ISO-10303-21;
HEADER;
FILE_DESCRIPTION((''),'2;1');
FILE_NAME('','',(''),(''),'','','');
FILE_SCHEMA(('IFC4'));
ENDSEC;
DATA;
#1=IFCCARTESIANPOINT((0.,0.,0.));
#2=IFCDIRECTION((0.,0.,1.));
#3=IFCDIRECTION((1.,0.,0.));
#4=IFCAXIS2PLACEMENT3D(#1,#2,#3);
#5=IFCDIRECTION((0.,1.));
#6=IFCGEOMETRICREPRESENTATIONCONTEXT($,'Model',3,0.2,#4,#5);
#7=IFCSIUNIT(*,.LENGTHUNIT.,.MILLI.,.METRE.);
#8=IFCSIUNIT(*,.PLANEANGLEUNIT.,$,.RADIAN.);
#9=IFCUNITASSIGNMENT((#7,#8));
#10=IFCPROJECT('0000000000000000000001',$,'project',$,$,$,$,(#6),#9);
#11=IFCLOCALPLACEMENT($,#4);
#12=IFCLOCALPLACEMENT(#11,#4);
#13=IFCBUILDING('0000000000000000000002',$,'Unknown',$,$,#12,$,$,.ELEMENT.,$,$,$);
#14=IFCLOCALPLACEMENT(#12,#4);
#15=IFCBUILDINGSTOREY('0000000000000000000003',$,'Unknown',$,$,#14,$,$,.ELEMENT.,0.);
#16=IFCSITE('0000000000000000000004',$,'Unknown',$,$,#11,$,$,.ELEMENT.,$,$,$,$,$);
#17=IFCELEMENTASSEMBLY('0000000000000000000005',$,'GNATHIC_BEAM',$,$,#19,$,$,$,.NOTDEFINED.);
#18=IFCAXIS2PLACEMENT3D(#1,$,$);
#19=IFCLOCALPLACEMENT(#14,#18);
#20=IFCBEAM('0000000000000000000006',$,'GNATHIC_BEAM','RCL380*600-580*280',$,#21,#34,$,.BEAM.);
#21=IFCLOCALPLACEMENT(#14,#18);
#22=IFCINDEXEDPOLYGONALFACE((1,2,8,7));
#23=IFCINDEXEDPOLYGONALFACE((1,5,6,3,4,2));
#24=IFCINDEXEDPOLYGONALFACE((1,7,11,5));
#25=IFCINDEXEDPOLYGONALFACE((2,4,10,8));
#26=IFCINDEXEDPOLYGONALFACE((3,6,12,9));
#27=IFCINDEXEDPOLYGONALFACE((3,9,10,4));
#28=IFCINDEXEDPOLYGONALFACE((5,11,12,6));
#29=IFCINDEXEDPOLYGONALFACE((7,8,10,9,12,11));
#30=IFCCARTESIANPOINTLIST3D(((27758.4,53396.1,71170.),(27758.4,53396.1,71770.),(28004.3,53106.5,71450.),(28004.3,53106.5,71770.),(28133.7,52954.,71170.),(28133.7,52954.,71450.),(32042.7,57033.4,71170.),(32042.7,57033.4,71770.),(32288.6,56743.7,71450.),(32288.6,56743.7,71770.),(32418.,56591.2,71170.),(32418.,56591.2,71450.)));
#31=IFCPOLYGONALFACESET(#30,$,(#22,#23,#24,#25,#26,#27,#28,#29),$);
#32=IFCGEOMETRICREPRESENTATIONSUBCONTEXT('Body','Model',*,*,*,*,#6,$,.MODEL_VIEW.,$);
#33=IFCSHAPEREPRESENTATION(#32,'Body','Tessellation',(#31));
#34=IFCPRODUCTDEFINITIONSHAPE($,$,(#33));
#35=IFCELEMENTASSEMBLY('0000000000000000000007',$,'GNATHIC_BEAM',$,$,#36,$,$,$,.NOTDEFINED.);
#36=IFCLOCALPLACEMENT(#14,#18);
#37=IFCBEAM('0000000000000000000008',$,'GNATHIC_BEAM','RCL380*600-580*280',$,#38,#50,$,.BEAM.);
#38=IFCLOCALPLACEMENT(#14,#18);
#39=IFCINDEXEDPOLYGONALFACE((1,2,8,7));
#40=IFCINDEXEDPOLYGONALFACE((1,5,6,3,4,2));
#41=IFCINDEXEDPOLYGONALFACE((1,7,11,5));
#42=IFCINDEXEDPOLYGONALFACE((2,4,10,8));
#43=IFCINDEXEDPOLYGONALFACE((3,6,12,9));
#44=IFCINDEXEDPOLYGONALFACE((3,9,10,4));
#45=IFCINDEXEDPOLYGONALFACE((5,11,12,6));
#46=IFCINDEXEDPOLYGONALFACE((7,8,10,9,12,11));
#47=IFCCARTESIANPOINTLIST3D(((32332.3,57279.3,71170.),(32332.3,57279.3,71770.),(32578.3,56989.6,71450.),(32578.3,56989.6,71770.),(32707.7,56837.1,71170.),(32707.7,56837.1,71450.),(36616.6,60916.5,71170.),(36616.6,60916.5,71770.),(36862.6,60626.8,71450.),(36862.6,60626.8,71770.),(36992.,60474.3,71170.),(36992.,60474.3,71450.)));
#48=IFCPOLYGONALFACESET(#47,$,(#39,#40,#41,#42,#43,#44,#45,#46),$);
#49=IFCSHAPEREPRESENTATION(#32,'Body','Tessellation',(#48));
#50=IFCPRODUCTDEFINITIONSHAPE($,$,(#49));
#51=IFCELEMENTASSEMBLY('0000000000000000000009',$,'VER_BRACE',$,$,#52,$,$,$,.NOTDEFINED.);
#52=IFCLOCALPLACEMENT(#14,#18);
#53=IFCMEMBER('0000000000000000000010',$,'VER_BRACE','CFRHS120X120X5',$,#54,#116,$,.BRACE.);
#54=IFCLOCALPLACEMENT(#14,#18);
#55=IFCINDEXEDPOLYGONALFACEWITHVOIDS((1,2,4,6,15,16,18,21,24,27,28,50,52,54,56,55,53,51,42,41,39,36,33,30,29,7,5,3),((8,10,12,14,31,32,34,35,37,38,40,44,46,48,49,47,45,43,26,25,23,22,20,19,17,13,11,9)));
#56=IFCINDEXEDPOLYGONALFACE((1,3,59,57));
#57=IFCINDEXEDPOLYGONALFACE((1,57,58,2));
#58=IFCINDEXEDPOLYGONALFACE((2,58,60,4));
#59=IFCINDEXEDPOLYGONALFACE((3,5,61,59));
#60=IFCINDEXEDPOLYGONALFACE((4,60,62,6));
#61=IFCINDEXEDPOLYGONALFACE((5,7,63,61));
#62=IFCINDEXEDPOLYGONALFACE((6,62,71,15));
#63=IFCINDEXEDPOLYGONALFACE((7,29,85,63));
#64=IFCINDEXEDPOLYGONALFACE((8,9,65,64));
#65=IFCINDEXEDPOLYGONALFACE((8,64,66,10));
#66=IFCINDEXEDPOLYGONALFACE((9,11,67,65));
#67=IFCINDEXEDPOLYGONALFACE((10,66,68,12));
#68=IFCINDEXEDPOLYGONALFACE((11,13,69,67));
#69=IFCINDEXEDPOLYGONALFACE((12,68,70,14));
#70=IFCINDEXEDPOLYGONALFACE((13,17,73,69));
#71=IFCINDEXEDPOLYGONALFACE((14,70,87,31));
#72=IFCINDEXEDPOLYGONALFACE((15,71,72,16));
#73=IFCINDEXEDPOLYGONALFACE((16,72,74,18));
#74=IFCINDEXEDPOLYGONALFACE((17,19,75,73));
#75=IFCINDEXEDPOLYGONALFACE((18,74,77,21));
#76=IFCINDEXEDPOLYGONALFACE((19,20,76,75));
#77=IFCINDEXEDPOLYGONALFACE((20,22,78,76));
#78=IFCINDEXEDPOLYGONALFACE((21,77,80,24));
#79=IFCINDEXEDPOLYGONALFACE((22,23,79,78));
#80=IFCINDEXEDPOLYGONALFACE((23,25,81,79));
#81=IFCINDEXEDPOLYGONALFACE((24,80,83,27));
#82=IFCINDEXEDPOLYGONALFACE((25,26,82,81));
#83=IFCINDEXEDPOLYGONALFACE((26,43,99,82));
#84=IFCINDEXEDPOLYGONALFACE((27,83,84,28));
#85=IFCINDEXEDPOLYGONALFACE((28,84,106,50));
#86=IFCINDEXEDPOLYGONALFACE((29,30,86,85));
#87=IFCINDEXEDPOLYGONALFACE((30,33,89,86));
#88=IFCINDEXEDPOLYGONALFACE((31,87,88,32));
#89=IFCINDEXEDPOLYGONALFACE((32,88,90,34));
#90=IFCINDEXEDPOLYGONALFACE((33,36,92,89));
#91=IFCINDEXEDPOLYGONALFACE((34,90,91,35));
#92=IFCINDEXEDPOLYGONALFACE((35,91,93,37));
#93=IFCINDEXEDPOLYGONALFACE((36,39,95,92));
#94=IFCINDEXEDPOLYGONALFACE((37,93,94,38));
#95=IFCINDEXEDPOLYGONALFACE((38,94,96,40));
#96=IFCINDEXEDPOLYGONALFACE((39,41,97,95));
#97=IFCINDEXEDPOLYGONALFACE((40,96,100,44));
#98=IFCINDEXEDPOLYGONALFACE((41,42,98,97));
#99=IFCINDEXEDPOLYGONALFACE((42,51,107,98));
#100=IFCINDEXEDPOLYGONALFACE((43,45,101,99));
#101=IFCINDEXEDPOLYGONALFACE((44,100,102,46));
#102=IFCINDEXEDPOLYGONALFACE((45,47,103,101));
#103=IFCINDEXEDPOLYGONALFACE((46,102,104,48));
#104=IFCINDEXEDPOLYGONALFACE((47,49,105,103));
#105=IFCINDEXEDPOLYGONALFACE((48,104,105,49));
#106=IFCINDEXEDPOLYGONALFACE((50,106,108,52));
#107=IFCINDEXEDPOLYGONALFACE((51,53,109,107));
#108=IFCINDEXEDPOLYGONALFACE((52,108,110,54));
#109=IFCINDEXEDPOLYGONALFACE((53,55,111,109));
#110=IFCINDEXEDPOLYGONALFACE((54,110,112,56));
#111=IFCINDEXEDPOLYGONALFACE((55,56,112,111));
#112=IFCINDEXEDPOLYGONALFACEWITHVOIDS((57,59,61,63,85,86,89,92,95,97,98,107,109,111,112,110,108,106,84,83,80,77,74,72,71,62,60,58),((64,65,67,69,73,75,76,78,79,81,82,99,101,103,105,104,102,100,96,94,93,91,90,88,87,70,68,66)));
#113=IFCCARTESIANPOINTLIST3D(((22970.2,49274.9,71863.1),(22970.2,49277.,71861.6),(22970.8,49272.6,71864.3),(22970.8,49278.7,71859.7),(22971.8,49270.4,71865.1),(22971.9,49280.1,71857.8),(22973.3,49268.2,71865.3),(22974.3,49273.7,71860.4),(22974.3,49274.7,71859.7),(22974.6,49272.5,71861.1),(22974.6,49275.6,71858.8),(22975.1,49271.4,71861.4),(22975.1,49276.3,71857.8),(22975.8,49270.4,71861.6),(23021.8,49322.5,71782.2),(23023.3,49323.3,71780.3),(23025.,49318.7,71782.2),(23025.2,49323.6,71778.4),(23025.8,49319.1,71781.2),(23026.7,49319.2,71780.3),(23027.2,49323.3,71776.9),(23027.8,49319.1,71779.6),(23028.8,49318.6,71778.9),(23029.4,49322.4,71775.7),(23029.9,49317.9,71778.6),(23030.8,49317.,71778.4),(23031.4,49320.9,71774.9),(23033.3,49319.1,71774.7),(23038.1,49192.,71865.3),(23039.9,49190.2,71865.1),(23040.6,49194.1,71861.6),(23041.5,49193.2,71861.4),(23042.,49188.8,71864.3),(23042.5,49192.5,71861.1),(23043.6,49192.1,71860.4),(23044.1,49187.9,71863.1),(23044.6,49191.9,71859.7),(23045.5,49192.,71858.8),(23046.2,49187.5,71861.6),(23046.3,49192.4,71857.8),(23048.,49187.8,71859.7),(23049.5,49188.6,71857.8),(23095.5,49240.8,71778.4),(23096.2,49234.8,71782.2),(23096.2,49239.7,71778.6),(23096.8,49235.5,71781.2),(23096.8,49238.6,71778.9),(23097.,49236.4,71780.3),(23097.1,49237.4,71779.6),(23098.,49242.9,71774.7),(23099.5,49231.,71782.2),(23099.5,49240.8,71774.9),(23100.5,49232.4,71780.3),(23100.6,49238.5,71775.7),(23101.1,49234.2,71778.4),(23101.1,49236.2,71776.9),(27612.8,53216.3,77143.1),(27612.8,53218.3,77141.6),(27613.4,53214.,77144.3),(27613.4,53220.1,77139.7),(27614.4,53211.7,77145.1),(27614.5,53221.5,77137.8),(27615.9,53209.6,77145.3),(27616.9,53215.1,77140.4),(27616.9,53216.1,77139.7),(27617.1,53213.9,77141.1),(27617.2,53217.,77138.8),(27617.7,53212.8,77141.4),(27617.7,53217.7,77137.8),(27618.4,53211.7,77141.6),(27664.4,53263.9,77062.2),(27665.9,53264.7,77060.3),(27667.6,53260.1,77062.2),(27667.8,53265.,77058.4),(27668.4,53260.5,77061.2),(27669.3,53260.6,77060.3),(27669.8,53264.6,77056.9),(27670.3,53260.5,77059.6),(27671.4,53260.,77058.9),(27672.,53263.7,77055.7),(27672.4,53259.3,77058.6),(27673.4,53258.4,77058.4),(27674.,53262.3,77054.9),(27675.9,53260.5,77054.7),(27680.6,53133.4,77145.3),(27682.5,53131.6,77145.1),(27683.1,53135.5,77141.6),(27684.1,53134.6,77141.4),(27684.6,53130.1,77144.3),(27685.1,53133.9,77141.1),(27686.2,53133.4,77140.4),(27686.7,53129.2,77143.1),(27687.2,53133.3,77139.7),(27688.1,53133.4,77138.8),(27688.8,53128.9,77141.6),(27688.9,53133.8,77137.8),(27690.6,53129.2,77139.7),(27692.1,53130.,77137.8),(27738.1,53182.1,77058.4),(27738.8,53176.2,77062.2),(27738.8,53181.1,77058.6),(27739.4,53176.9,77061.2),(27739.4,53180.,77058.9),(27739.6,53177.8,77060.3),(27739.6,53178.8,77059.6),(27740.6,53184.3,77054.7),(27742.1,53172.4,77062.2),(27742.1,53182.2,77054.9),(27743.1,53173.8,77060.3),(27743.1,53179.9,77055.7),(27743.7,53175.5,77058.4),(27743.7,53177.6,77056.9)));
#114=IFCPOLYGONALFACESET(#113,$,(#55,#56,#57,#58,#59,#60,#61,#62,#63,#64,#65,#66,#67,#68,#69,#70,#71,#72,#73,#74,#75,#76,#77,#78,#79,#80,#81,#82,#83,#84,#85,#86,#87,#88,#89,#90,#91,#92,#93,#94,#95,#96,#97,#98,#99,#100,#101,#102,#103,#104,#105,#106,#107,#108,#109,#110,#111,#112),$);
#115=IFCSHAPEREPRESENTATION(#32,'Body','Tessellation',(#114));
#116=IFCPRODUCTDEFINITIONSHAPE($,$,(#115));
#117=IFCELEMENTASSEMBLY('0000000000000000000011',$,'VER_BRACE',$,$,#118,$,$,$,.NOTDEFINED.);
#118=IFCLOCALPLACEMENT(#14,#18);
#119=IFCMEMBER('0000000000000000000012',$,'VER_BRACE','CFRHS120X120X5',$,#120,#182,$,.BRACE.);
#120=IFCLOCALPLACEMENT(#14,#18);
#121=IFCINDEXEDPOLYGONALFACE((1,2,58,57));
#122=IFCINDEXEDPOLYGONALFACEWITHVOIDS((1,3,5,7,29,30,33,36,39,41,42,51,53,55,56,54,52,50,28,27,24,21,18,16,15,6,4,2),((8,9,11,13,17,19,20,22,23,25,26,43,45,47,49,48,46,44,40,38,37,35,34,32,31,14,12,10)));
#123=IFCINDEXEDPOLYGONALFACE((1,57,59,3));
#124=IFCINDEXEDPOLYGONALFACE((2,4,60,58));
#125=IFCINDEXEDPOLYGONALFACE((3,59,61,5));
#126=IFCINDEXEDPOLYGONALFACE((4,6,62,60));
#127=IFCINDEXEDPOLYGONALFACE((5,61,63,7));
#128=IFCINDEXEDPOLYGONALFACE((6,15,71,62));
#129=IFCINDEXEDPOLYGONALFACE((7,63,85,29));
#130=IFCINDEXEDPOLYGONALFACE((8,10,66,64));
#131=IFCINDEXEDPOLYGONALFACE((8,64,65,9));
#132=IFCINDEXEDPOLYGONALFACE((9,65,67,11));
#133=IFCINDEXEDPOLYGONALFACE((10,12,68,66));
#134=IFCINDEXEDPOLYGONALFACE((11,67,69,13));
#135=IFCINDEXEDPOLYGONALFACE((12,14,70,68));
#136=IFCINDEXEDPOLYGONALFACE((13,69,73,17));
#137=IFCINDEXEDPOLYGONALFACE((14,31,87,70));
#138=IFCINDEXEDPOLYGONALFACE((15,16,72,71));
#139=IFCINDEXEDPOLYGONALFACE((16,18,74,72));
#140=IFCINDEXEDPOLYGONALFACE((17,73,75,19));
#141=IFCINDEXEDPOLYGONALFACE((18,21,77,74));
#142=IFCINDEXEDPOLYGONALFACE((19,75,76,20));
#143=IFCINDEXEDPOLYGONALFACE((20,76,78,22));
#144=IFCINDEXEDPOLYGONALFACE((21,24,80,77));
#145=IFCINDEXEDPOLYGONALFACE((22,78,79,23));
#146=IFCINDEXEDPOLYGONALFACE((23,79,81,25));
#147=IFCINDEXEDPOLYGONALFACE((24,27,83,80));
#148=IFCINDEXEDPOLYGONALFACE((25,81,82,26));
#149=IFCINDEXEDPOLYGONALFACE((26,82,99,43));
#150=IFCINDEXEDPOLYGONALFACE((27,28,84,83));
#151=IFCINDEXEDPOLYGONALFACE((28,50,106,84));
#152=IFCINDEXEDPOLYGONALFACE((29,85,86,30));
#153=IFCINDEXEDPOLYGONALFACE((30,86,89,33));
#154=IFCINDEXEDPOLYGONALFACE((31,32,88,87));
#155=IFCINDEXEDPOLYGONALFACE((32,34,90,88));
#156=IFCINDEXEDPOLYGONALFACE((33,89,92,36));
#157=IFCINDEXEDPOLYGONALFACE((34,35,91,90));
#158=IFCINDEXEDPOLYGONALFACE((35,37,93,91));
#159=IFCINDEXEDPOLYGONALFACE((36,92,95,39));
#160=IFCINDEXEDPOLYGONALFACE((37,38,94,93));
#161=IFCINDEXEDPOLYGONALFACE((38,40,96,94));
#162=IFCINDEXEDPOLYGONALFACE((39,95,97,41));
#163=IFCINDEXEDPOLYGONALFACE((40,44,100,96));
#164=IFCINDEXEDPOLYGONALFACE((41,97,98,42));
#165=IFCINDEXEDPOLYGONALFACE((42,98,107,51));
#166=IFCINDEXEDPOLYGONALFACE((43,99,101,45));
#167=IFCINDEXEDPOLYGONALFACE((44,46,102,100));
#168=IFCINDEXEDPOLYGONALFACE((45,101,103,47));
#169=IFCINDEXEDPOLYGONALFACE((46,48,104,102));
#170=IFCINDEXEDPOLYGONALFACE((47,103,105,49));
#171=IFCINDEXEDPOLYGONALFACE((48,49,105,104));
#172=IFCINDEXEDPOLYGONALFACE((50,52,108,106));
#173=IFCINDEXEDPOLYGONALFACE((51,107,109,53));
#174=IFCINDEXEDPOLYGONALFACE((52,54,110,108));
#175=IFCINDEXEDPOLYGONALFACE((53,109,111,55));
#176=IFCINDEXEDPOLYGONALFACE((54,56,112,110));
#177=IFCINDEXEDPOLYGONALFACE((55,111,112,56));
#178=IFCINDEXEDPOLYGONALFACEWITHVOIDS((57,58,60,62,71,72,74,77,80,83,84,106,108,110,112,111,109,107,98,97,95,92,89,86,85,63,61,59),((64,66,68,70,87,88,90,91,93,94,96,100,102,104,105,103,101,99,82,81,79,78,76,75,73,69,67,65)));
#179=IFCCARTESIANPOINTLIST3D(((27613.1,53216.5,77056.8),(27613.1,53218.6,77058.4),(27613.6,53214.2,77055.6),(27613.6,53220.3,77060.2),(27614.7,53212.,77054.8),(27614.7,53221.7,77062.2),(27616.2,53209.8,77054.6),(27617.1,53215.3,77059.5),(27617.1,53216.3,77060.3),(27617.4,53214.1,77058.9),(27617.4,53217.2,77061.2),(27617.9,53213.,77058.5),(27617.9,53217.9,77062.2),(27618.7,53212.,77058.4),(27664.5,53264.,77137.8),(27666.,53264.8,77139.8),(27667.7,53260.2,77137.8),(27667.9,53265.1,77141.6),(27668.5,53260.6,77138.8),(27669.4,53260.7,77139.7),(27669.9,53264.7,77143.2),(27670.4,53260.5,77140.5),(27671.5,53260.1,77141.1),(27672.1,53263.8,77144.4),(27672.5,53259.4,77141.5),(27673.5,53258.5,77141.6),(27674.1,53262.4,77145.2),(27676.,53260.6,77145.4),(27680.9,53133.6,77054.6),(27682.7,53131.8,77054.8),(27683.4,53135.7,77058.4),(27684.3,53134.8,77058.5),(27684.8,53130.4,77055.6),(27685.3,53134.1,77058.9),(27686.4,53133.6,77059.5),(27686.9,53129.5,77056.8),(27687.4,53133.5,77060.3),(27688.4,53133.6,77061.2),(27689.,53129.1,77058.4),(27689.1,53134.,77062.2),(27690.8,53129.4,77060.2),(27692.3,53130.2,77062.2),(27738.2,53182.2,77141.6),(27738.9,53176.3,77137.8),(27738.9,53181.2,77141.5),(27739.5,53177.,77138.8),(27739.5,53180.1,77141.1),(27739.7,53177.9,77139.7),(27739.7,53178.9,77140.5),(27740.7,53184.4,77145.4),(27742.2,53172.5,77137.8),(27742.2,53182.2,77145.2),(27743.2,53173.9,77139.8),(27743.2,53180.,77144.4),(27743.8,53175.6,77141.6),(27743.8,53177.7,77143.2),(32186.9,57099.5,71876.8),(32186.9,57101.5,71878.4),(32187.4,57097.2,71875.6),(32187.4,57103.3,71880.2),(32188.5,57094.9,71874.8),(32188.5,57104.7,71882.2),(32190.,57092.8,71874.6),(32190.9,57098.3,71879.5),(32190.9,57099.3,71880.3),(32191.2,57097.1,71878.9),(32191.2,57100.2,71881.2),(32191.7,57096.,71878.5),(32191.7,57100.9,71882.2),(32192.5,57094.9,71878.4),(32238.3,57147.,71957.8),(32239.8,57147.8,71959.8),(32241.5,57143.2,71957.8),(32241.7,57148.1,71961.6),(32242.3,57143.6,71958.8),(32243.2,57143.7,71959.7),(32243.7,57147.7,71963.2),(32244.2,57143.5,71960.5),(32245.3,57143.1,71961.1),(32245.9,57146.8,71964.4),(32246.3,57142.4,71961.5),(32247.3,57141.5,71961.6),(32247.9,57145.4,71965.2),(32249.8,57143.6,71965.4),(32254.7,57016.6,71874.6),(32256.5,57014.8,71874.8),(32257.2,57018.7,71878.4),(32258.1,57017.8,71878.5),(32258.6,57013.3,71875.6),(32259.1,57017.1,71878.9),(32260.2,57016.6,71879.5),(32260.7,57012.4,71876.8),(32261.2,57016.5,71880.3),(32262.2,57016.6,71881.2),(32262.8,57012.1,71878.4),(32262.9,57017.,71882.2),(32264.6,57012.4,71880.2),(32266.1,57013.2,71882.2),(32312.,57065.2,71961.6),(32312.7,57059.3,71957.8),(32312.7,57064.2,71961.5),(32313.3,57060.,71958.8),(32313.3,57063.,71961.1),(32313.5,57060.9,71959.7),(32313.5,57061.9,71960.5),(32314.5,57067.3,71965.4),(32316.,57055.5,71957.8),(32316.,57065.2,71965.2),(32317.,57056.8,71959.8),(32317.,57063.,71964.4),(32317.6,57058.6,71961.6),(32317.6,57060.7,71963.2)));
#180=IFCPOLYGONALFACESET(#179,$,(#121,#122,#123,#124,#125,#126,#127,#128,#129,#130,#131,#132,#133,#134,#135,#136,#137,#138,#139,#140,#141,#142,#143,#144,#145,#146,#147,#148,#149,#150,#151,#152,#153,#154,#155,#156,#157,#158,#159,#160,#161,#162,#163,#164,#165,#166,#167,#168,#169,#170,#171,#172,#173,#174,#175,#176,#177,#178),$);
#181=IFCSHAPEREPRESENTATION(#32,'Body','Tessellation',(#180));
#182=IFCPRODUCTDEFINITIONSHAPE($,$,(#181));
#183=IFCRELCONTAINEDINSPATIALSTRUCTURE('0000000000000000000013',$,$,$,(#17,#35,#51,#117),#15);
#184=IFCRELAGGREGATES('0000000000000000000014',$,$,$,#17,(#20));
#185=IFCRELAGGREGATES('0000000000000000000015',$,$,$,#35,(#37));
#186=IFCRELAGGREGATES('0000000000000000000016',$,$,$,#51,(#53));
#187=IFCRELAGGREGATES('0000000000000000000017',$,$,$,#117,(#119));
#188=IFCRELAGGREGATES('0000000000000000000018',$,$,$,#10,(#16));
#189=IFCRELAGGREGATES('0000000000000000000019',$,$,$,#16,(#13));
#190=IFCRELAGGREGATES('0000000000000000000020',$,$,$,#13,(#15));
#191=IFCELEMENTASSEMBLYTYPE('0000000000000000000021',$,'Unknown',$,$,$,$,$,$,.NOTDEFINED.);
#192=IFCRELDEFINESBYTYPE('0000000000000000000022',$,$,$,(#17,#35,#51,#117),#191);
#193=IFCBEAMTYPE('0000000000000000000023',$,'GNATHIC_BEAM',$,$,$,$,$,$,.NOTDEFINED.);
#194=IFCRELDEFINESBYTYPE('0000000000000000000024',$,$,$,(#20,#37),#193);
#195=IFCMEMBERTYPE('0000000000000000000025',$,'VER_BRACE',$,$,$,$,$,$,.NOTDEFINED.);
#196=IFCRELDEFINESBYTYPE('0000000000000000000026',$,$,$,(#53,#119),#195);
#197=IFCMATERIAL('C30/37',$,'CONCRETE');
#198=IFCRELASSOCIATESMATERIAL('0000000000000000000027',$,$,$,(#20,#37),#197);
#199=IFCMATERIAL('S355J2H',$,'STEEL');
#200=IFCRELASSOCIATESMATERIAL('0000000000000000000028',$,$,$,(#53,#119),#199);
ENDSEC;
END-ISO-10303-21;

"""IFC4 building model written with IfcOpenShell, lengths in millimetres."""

from ifc_helpers import new_model, si_unit, direction, frame, origin_with_axes, origin_2d_with_axis, place, context, subcontext, project, spatial, polyline, hollow_rectangle, outline, extrude, material, material_profile, profile_set, profile_usage, type_object, element, aggregate, save


model = new_model("IFC4")

# Units and contexts
model_context = context("Model", 3, precision=0.2, world=origin_with_axes(), true_north=direction((0.0, 1.0)))
body_context = subcontext(model_context, "Body", "Model", "MODEL_VIEW")
ifc_project = project(units=[si_unit("LENGTHUNIT", "METRE", prefix="MILLI"), si_unit("PLANEANGLEUNIT", "RADIAN")], contexts=[model_context])

# Site, building, storey
site_placement = place(None, origin_with_axes())
site = spatial("IfcSite", under=ifc_project, at=site_placement, Name="Unknown", CompositionType="ELEMENT")
building_placement = place(site_placement, origin_with_axes())
building = spatial("IfcBuilding", under=site, at=building_placement, Name="Unknown", CompositionType="ELEMENT")
storey_placement = place(building_placement, origin_with_axes())
storey = spatial("IfcBuildingStorey", under=building, at=storey_placement, Name="Unknown", CompositionType="ELEMENT", Elevation=0.0)

# Shared definitions
element_assembly_type = type_object("IfcElementAssemblyType", Name="Unknown", PredefinedType="NOTDEFINED")

# Element assemblies, beams
ifc_material_1 = material(Name="C30/37", Category="CONCRETE")
ifc_material_profile_1 = material_profile(ifc_material_1, outline(polyline([(-190.0, -300.0), (390.0, -300.0), (390.0, -20.0), (190.0, -20.0), (190.0, 300.0), (-190.0, 300.0), (-190.0, -300.0)])), Name="RCL380*600-580*280")
ifc_profile_set_1 = profile_set([ifc_material_profile_1])
ifc_profile_usage_1 = profile_usage(ifc_profile_set_1, cardinal=2)
beam_type_1 = type_object("IfcBeamType", Name="GNATHIC_BEAM")
assembly_1_placement = place(storey_placement, frame((27881.3, 53251.3, 71470.0), z_axis=(0.64719, -0.762329, 0.0), x_axis=(0.762329, 0.64719, 0.0)))
assembly_1 = element("IfcElementAssembly", 1, at=assembly_1_placement, inside=storey, type_object=element_assembly_type, Name="GNATHIC_BEAM", PredefinedType="NOTDEFINED")
beam_1_placement = place(assembly_1_placement, origin_with_axes())
beam_1 = element("IfcBeam", 2, at=beam_1_placement, type_object=beam_type_1, material=ifc_profile_usage_1, Name="GNATHIC_BEAM", Description="RCL380*600-580*280", PredefinedType="BEAM", context=body_context, shape_type="SolidModel", body=[
    extrude(outline(polyline([(-190.0, -300.0), (390.0, -300.0), (390.0, -20.0), (190.0, -20.0), (190.0, 300.0), (-190.0, 300.0), (-190.0, -300.0)])), frame((0.0, 0.0, 0.0), z_axis=(-1.0, 0.0, 0.0), x_axis=(0.0, 0.0, 1.0)), (0.0, 0.0, -1.0), 5620.0),
])
aggregate(assembly_1, [beam_1])
assembly_2_placement = place(storey_placement, frame((32455.3, 57134.4, 71470.0), z_axis=(0.64719, -0.762329, 0.0), x_axis=(0.762329, 0.64719, 0.0)))
assembly_2 = element("IfcElementAssembly", 3, at=assembly_2_placement, inside=storey, type_object=element_assembly_type, Name="GNATHIC_BEAM", PredefinedType="NOTDEFINED")
beam_2_placement = place(assembly_2_placement, origin_with_axes())
beam_2 = element("IfcBeam", 4, at=beam_2_placement, type_object=beam_type_1, material=ifc_profile_usage_1, Name="GNATHIC_BEAM", Description="RCL380*600-580*280", PredefinedType="BEAM", context=body_context, shape_type="SolidModel", body=[
    extrude(outline(polyline([(-190.0, -300.0), (390.0, -300.0), (390.0, -20.0), (190.0, -20.0), (190.0, 300.0), (-190.0, 300.0), (-190.0, -300.0)])), frame((0.0, 0.0, 0.0), z_axis=(-1.0, 0.0, 0.0), x_axis=(0.0, 0.0, 1.0)), (0.0, 0.0, -1.0), 5620.0),
])
aggregate(assembly_2, [beam_2])

# Element assemblies, members
assembly_3_placement = place(storey_placement, frame((23035.7, 49255.6, 71820.0), z_axis=(0.64719, -0.762329, 0.0), x_axis=(0.57599, 0.488995, 0.655072)))
assembly_3 = element("IfcElementAssembly", 5, at=assembly_3_placement, inside=storey, type_object=element_assembly_type, Name="VER_BRACE", PredefinedType="NOTDEFINED")
ifc_material_2 = material(Name="S355J2H", Category="STEEL")
ifc_material_profile_2 = material_profile(ifc_material_2, hollow_rectangle(XDim=120.0, YDim=120.0, WallThickness=5.0, InnerFilletRadius=5.0, OuterFilletRadius=10.0, at=origin_2d_with_axis()), Name="CFRHS120X120X5")
ifc_profile_set_2 = profile_set([ifc_material_profile_2])
ifc_profile_usage_2 = profile_usage(ifc_profile_set_2, cardinal=5)
member_type = type_object("IfcMemberType", Name="VER_BRACE")
member_1_placement = place(assembly_3_placement, origin_with_axes())
member_1 = element("IfcMember", 6, at=member_1_placement, type_object=member_type, material=ifc_profile_usage_2, Name="VER_BRACE", Description="CFRHS120X120X5", PredefinedType="BRACE", context=body_context, shape_type="SolidModel", body=[
    extrude(hollow_rectangle(XDim=120.0, YDim=120.0, WallThickness=5.0, InnerFilletRadius=5.0, OuterFilletRadius=10.0, at=origin_2d_with_axis()), frame((0.0, 0.0, 0.0), z_axis=(-1.0, 0.0, 0.0), x_axis=(0.0, 0.0, 1.0)), (0.0, 0.0, -1.0), 8060.2),
])
aggregate(assembly_3, [member_1])
assembly_4_placement = place(storey_placement, frame((27678.4, 53197.1, 77100.0), z_axis=(0.64719, -0.762329, 0.0), x_axis=(0.577025, 0.489874, -0.653503)))
assembly_4 = element("IfcElementAssembly", 7, at=assembly_4_placement, inside=storey, type_object=element_assembly_type, Name="VER_BRACE", PredefinedType="NOTDEFINED")
member_2_placement = place(assembly_4_placement, origin_with_axes())
member_2 = element("IfcMember", 8, at=member_2_placement, type_object=member_type, material=ifc_profile_usage_2, Name="VER_BRACE", Description="CFRHS120X120X5", PredefinedType="BRACE", context=body_context, shape_type="SolidModel", body=[
    extrude(hollow_rectangle(XDim=120.0, YDim=120.0, WallThickness=5.0, InnerFilletRadius=5.0, OuterFilletRadius=10.0, at=origin_2d_with_axis()), frame((0.0, 0.0, 0.0), z_axis=(-1.0, 0.0, 0.0), x_axis=(0.0, 0.0, 1.0)), (0.0, 0.0, -1.0), 7926.5),
])
aggregate(assembly_4, [member_2])

save(model, "model.ifc")
